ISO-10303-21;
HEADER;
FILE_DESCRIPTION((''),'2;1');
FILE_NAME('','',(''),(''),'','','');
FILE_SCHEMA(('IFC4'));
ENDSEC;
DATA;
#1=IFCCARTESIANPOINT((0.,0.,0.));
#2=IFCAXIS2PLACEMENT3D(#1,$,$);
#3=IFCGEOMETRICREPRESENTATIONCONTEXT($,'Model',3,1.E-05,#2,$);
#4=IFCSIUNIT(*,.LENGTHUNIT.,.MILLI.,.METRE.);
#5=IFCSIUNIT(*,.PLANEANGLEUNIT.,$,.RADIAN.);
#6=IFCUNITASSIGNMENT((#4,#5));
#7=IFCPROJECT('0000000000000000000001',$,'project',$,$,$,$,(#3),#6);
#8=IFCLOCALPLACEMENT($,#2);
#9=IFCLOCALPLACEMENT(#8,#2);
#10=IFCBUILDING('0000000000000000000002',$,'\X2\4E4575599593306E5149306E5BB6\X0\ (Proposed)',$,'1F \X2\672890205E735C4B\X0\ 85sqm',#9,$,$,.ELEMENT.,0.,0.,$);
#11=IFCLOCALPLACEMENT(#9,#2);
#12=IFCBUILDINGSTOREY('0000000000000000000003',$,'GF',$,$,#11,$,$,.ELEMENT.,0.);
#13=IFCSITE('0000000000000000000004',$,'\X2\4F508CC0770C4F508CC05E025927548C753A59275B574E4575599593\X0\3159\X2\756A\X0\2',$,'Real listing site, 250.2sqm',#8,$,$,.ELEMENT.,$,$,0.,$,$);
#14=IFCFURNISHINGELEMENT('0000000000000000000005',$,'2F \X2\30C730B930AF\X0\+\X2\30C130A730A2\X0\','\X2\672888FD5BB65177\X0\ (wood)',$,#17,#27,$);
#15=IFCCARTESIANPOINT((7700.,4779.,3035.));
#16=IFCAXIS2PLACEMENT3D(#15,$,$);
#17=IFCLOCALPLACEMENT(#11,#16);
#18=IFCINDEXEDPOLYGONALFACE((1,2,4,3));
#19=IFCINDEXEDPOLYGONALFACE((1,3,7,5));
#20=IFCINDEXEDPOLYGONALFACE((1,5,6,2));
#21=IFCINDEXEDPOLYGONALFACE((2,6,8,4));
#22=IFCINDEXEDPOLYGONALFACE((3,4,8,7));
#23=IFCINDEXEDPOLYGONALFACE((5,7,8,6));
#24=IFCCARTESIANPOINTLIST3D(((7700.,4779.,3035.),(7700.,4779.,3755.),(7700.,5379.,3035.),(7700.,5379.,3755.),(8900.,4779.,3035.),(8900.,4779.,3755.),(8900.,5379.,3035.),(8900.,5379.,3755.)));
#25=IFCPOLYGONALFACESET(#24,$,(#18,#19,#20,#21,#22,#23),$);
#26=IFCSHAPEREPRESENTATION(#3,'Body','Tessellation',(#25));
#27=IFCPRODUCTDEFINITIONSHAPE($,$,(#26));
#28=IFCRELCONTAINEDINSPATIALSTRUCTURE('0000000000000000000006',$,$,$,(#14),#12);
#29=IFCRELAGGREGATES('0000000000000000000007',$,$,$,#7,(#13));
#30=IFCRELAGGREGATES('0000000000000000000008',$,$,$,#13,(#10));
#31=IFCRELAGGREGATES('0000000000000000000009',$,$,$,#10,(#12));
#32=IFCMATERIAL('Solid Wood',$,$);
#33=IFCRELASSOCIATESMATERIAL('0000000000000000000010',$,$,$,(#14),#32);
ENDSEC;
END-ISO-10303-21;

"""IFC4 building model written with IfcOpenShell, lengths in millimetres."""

from ifc_helpers import new_model, si_unit, frame, frame_2d, origin, place, context, project, spatial, rectangle, extrude, material, element, save


model = new_model("IFC4")

# Units and contexts
model_context = context("Model", 3, precision=1e-05, world=origin())
ifc_project = project(units=[si_unit("LENGTHUNIT", "METRE", prefix="MILLI"), si_unit("PLANEANGLEUNIT", "RADIAN")], contexts=[model_context])

# Site, building, storey
site_placement = place(None, origin())
site = spatial("IfcSite", under=ifc_project, at=site_placement, Name="佐賀県佐賀市大和町大字久留間3159番2", ObjectType="Real listing site, 250.2sqm", CompositionType="ELEMENT", RefElevation=0.0)
building_placement = place(site_placement, origin())
building = spatial("IfcBuilding", under=site, at=building_placement, Name="久留間の光の家 (Proposed)", ObjectType="1F 木造平屋 85sqm", CompositionType="ELEMENT", ElevationOfRefHeight=0.0, ElevationOfTerrain=0.0)
storey_placement = place(building_placement, origin())
storey = spatial("IfcBuildingStorey", under=building, at=storey_placement, Name="GF", CompositionType="ELEMENT", Elevation=0.0)

# Shared definitions
ifc_material_1 = material(Name="Solid Wood")

# Furnishing element
furnishing_1_placement = place(storey_placement, frame((7700.0, 4779.0, 3035.0)))
element("IfcFurnishingElement", 1, at=furnishing_1_placement, inside=storey, material=ifc_material_1, Name="2F デスク+チェア", Description="木製家具 (wood)", context=model_context, shape_type="SweptSolid", body=[
    extrude(rectangle(XDim=1200.0, YDim=600.0, at=frame_2d((600.0, 300.0))), frame((7700.0, 4779.0, 3035.0)), (0.0, 0.0, 1.0), 720.0),
])

save(model, "model.ifc")
